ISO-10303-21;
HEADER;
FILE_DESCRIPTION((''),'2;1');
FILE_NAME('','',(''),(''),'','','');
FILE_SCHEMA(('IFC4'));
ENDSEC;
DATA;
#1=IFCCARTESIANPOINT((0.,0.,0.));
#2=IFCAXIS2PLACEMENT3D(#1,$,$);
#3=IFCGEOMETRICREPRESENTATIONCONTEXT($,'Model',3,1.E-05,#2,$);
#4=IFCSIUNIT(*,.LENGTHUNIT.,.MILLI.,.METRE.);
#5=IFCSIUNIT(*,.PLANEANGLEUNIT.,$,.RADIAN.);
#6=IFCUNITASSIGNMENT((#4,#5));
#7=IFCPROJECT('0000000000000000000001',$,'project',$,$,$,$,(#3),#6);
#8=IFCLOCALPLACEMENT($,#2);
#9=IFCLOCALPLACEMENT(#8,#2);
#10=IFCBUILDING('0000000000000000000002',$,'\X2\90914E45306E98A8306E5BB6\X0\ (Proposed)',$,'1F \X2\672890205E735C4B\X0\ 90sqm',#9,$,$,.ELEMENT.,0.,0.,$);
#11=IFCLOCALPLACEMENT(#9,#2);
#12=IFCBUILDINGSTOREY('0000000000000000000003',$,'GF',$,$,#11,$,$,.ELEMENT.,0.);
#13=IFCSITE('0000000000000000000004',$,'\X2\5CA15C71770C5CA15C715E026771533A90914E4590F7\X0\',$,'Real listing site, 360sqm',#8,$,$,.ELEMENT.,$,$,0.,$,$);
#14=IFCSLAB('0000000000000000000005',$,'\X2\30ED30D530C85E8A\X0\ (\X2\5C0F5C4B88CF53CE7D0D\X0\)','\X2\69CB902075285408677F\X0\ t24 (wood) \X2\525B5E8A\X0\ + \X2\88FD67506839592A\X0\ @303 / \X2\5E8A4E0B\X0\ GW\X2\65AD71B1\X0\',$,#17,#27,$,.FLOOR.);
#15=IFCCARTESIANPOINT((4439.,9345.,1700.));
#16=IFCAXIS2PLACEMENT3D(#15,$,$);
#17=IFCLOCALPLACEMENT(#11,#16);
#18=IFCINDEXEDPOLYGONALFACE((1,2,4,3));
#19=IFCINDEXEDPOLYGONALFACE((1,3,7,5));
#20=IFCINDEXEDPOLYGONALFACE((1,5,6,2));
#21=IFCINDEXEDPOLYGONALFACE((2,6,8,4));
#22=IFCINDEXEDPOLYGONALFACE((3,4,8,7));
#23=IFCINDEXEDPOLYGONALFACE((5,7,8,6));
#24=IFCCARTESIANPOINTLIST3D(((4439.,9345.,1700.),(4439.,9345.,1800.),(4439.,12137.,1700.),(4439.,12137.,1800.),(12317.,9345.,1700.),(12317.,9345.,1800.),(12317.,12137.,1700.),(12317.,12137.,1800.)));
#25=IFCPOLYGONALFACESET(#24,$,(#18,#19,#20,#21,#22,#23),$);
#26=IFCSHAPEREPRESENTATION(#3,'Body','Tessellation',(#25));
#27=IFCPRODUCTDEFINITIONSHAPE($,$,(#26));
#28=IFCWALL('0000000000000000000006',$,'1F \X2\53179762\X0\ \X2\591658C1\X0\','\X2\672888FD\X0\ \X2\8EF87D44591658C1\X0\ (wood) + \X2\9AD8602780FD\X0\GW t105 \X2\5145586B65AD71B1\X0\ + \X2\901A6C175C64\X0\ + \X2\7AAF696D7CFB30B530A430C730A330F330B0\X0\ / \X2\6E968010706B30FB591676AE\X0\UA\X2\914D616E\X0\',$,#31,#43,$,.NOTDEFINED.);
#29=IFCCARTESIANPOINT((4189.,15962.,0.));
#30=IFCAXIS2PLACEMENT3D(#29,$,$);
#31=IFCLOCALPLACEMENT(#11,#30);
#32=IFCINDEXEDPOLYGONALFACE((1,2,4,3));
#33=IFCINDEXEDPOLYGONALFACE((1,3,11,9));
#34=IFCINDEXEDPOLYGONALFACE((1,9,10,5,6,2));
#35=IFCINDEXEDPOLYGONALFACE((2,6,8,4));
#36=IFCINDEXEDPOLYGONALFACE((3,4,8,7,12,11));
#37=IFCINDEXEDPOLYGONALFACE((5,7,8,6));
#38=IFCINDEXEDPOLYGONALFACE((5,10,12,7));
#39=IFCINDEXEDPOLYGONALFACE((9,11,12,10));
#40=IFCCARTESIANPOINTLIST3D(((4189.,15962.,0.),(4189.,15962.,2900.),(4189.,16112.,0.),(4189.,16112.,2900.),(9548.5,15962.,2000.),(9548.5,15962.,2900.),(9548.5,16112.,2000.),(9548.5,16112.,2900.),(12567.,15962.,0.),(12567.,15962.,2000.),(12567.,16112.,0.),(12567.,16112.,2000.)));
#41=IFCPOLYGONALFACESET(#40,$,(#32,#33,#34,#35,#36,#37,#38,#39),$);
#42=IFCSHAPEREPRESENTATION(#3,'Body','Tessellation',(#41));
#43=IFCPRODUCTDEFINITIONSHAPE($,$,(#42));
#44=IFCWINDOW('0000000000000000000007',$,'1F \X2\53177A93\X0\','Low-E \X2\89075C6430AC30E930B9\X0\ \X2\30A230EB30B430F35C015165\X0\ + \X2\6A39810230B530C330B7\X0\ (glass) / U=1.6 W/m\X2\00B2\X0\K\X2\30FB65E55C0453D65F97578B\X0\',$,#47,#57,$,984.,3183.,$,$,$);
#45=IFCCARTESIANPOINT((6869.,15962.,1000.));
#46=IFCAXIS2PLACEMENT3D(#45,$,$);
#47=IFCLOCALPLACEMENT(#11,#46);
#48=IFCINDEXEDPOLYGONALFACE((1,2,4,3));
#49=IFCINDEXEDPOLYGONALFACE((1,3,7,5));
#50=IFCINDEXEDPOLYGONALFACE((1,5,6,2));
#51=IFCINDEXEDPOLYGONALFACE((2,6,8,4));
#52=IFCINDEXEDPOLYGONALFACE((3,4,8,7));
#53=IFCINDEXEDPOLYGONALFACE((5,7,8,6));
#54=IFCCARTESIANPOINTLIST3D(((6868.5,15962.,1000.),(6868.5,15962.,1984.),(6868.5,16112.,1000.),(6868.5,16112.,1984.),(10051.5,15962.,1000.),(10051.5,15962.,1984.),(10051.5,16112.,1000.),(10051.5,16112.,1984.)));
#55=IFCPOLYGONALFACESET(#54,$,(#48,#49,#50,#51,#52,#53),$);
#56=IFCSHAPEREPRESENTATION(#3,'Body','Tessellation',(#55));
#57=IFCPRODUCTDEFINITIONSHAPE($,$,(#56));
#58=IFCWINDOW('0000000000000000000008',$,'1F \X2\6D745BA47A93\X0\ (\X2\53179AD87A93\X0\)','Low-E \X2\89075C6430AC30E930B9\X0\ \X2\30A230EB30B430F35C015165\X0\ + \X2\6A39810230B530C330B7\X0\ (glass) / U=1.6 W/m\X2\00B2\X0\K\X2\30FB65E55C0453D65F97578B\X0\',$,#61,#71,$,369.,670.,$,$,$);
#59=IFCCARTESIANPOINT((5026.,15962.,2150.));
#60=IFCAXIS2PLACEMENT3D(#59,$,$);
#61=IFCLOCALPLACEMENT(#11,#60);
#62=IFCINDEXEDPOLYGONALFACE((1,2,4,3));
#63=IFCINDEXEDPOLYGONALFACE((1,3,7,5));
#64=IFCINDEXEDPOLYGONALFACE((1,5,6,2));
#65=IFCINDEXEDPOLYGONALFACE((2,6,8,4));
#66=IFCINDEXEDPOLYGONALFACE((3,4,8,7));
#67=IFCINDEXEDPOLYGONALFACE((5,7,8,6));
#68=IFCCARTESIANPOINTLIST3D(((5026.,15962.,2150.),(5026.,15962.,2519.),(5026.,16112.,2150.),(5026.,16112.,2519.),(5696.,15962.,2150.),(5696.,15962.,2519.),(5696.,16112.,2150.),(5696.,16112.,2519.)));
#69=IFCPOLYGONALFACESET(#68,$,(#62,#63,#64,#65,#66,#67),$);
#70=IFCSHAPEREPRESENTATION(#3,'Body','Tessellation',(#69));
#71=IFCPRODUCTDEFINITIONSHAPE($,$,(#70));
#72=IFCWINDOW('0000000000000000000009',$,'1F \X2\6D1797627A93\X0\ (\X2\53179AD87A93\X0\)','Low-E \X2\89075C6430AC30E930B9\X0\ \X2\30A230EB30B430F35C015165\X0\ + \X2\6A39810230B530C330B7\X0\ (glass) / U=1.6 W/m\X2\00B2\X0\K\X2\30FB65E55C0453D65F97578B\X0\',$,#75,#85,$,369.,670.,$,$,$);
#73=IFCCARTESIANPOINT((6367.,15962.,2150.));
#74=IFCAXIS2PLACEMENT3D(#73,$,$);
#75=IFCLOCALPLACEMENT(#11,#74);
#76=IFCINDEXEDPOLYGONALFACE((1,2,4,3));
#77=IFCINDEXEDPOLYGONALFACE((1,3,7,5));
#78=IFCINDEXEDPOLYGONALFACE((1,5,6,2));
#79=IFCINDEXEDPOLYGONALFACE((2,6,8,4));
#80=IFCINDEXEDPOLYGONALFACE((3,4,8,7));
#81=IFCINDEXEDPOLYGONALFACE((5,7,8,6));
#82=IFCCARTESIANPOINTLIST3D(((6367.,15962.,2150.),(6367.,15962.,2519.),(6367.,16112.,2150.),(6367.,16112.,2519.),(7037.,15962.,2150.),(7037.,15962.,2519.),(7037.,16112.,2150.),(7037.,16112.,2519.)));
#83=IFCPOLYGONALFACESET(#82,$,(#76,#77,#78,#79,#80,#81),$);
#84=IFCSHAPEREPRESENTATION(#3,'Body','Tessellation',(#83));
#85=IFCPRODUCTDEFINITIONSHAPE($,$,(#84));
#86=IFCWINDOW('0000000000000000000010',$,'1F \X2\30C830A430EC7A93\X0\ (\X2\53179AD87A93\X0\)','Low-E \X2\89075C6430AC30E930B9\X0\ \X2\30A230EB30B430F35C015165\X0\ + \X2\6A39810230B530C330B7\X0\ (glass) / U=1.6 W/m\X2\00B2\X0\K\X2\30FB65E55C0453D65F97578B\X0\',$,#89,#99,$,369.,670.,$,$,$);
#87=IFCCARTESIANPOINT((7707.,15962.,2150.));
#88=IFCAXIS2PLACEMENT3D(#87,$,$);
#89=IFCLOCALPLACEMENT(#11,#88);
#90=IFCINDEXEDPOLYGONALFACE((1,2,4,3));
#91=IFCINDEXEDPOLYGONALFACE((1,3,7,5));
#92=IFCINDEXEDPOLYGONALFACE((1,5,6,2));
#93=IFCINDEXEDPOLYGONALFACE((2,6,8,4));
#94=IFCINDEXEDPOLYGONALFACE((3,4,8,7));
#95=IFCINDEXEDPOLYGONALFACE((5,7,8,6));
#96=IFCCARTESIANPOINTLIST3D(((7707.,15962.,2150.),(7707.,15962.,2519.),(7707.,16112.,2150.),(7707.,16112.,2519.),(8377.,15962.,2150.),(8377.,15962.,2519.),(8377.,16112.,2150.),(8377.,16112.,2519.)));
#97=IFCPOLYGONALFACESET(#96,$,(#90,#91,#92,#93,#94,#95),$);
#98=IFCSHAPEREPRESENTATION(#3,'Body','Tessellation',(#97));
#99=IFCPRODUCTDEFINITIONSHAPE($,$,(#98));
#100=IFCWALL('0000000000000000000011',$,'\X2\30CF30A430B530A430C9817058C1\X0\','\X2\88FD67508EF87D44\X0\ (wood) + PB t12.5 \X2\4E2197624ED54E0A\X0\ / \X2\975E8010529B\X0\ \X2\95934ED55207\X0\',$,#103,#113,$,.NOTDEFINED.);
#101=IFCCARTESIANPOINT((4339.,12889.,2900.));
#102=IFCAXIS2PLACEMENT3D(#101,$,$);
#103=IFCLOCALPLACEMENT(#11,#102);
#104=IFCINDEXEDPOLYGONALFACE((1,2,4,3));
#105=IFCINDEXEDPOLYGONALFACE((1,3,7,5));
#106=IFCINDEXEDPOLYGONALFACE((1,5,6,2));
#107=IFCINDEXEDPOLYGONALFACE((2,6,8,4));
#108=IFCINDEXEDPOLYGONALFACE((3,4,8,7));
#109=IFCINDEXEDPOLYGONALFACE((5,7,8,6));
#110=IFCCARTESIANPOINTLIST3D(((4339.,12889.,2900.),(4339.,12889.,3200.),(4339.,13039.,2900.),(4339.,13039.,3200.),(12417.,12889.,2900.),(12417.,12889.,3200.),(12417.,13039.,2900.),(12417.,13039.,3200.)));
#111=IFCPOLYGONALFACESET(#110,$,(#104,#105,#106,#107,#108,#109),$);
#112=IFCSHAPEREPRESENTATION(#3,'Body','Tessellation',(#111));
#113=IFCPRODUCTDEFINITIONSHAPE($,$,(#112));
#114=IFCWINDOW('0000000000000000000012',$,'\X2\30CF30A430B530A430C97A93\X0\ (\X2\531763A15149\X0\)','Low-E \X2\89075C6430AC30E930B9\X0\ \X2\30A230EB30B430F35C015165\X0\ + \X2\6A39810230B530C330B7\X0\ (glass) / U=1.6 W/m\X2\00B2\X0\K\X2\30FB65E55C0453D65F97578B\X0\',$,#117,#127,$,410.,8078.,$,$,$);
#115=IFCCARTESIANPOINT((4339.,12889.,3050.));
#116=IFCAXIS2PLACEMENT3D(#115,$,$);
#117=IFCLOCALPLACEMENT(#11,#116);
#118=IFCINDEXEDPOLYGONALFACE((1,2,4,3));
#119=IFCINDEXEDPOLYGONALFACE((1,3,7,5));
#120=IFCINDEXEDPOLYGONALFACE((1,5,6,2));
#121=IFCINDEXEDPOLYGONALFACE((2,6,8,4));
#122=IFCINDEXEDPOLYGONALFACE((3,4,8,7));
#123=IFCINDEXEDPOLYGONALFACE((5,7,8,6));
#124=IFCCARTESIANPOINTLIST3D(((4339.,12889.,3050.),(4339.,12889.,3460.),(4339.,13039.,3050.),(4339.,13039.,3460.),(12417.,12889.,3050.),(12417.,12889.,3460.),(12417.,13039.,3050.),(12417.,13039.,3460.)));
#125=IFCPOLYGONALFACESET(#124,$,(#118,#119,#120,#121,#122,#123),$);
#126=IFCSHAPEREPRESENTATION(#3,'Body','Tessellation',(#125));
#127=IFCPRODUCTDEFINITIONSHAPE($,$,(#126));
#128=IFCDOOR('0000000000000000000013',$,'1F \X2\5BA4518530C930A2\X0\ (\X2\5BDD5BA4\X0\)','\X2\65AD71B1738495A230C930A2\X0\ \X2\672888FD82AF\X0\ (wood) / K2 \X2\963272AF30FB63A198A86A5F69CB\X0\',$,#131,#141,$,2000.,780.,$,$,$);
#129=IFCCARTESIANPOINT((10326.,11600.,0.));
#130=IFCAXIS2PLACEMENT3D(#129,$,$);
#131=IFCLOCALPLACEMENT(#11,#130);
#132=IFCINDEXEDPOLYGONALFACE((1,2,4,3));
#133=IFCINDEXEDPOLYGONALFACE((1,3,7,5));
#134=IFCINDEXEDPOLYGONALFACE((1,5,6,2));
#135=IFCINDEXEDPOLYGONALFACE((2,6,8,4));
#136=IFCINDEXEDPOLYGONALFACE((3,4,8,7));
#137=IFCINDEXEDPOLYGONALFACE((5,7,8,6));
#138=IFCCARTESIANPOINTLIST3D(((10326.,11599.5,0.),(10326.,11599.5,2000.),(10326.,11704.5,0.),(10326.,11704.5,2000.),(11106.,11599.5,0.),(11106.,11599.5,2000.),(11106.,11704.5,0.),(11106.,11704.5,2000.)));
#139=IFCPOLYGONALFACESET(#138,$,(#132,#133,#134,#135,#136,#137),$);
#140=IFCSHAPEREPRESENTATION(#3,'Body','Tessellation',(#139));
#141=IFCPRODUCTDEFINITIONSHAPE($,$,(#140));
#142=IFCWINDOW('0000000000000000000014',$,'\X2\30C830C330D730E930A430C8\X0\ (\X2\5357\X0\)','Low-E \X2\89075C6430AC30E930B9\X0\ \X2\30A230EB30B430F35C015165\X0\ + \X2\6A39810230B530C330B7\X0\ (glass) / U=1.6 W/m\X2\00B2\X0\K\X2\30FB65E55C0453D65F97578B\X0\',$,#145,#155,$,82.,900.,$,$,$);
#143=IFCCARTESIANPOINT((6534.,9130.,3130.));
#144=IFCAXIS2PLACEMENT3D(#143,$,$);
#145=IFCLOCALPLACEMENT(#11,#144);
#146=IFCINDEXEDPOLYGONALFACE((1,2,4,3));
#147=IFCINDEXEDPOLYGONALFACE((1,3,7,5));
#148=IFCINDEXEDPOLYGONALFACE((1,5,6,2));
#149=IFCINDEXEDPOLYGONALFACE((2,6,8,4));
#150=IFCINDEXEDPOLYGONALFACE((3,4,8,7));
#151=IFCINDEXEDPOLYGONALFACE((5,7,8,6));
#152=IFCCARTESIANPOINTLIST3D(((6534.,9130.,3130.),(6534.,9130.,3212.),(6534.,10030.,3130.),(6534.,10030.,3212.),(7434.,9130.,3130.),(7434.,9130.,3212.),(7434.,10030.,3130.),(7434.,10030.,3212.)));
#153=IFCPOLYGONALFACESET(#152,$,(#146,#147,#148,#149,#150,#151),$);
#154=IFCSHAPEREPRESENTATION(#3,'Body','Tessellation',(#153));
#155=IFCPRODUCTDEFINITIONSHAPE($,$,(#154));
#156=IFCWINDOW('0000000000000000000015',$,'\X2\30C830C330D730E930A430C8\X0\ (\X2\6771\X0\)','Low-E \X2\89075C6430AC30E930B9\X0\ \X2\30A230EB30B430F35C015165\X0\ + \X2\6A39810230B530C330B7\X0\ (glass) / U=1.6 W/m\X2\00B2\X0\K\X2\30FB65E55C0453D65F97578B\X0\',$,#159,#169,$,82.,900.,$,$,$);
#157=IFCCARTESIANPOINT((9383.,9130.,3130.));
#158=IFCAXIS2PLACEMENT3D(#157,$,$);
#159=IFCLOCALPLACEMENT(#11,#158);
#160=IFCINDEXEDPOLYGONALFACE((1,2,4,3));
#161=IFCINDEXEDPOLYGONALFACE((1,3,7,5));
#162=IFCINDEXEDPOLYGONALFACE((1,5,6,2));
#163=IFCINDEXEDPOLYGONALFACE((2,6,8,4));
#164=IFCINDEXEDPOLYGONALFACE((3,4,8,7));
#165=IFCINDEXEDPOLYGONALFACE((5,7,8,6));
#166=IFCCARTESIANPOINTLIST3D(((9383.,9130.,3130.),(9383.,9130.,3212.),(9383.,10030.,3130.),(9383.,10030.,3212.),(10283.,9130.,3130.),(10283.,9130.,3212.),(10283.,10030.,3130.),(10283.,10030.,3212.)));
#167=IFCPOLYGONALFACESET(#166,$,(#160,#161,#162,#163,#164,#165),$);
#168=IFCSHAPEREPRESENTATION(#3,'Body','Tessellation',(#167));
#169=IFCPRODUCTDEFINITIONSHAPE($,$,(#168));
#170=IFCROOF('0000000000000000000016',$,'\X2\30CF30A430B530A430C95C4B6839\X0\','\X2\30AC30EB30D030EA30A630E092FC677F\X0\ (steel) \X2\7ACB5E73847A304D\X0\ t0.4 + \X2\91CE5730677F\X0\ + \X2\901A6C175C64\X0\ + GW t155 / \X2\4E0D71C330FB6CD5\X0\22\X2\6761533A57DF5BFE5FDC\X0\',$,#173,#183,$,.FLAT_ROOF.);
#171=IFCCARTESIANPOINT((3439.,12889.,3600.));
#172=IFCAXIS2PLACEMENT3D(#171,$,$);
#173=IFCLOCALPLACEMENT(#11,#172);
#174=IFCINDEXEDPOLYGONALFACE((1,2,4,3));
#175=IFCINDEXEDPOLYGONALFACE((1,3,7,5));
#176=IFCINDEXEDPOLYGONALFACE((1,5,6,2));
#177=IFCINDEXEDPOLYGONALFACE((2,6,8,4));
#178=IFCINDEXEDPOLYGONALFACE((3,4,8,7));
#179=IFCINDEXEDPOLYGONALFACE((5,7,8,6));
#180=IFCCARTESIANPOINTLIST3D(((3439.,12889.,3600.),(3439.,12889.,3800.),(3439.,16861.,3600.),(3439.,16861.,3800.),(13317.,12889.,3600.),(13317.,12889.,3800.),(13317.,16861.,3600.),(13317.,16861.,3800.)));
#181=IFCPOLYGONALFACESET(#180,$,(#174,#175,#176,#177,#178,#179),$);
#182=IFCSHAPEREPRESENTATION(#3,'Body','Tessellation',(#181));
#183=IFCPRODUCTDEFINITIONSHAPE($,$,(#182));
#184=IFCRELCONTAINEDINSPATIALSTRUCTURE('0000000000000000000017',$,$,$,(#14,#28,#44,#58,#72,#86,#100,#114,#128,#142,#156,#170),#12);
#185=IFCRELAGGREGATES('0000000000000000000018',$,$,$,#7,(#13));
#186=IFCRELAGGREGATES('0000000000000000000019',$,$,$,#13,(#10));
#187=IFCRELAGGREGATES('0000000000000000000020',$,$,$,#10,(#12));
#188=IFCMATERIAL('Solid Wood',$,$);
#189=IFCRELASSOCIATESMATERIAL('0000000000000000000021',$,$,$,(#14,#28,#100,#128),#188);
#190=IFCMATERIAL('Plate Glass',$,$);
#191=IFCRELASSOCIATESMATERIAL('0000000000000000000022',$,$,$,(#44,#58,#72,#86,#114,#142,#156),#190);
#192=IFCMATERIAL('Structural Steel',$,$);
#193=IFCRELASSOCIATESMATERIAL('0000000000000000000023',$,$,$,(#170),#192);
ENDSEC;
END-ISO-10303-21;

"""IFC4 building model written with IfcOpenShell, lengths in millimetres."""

from ifc_helpers import new_model, si_unit, frame, frame_2d, origin, place, context, project, spatial, rectangle, extrude, material, element, fill, save


model = new_model("IFC4")

# Units and contexts
model_context = context("Model", 3, precision=1e-05, world=origin())
ifc_project = project(units=[si_unit("LENGTHUNIT", "METRE", prefix="MILLI"), si_unit("PLANEANGLEUNIT", "RADIAN")], contexts=[model_context])

# Site, building, storey
site_placement = place(None, origin())
site = spatial("IfcSite", under=ifc_project, at=site_placement, Name="岡山県岡山市東区邑久郷", ObjectType="Real listing site, 360sqm", CompositionType="ELEMENT", RefElevation=0.0)
building_placement = place(site_placement, origin())
building = spatial("IfcBuilding", under=site, at=building_placement, Name="邑久の風の家 (Proposed)", ObjectType="1F 木造平屋 90sqm", CompositionType="ELEMENT", ElevationOfRefHeight=0.0, ElevationOfTerrain=0.0)
storey_placement = place(building_placement, origin())
storey = spatial("IfcBuildingStorey", under=building, at=storey_placement, Name="GF", CompositionType="ELEMENT", Elevation=0.0)

# Slab
ifc_material_1 = material(Name="Solid Wood")
slab_placement = place(storey_placement, frame((4439.0, 9345.0, 1700.0)))
element("IfcSlab", 1, at=slab_placement, inside=storey, material=ifc_material_1, Name="ロフト床 (小屋裏収納)", Description="構造用合板 t24 (wood) 剛床 + 製材根太 @303 / 床下 GW断熱", PredefinedType="FLOOR", context=model_context, shape_type="SweptSolid", body=[
    extrude(rectangle(XDim=7878.0, YDim=2792.0, at=frame_2d((3939.0, 1396.0))), frame((4439.0, 9345.0, 1700.0)), (0.0, 0.0, 1.0), 100.0),
])

# Wall, openings, windows
wall_1_placement = place(storey_placement, frame((4189.0, 15962.0, 0.0)))
wall_1 = element("IfcWall", 2, at=wall_1_placement, inside=storey, material=ifc_material_1, Name="1F 北面 外壁", Description="木製 軸組外壁 (wood) + 高性能GW t105 充填断熱 + 通気層 + 窯業系サイディング / 準耐火・外皮UA配慮", PredefinedType="NOTDEFINED", context=model_context, shape_type="SweptSolid", body=[
    extrude(rectangle(XDim=8378.0, YDim=150.0, at=frame_2d((4189.0, 75.0))), frame((4189.0, 15962.0, 0.0)), (0.0, 0.0, 1.0), 2900.0),
])
opening_1_placement = place(storey_placement, frame((6869.0, 15962.0, 1000.0)))
opening_1 = element("IfcOpeningElement", 3, at=opening_1_placement, cuts=wall_1, PredefinedType="NOTDEFINED", context=model_context, shape_type="SweptSolid", body=[
    extrude(rectangle(XDim=3183.0, YDim=150.0, at=frame_2d((1591.0, 75.0))), frame((6869.0, 15962.0, 1000.0)), (0.0, 0.0, 1.0), 984.0),
])
opening_2_placement = place(storey_placement, frame((5026.0, 15962.0, 2150.0)))
opening_2 = element("IfcOpeningElement", 4, at=opening_2_placement, cuts=wall_1, PredefinedType="NOTDEFINED", context=model_context, shape_type="SweptSolid", body=[
    extrude(rectangle(XDim=670.0, YDim=150.0, at=frame_2d((335.0, 75.0))), frame((5026.0, 15962.0, 2150.0)), (0.0, 0.0, 1.0), 369.0),
])
opening_3_placement = place(storey_placement, frame((6367.0, 15962.0, 2150.0)))
opening_3 = element("IfcOpeningElement", 5, at=opening_3_placement, cuts=wall_1, PredefinedType="NOTDEFINED", context=model_context, shape_type="SweptSolid", body=[
    extrude(rectangle(XDim=670.0, YDim=150.0, at=frame_2d((335.0, 75.0))), frame((6367.0, 15962.0, 2150.0)), (0.0, 0.0, 1.0), 369.0),
])
opening_4_placement = place(storey_placement, frame((7707.0, 15962.0, 2150.0)))
opening_4 = element("IfcOpeningElement", 6, at=opening_4_placement, cuts=wall_1, PredefinedType="NOTDEFINED", context=model_context, shape_type="SweptSolid", body=[
    extrude(rectangle(XDim=670.0, YDim=150.0, at=frame_2d((335.0, 75.0))), frame((7707.0, 15962.0, 2150.0)), (0.0, 0.0, 1.0), 369.0),
])
ifc_material_2 = material(Name="Plate Glass")
window_1_placement = place(storey_placement, frame((6869.0, 15962.0, 1000.0)))
window_1 = element("IfcWindow", 7, at=window_1_placement, inside=storey, material=ifc_material_2, Name="1F 北窓", Description="Low-E 複層ガラス アルゴン封入 + 樹脂サッシ (glass) / U=1.6 W/m²K・日射取得型", OverallHeight=984.0, OverallWidth=3183.0, context=model_context, shape_type="SweptSolid", body=[
    extrude(rectangle(XDim=3183.0, YDim=150.0, at=frame_2d((1591.0, 75.0))), frame((6869.0, 15962.0, 1000.0)), (0.0, 0.0, 1.0), 984.0),
])
fill(opening_1, window_1)
window_2_placement = place(storey_placement, frame((5026.0, 15962.0, 2150.0)))
window_2 = element("IfcWindow", 8, at=window_2_placement, inside=storey, material=ifc_material_2, Name="1F 浴室窓 (北高窓)", Description="Low-E 複層ガラス アルゴン封入 + 樹脂サッシ (glass) / U=1.6 W/m²K・日射取得型", OverallHeight=369.0, OverallWidth=670.0, context=model_context, shape_type="SweptSolid", body=[
    extrude(rectangle(XDim=670.0, YDim=150.0, at=frame_2d((335.0, 75.0))), frame((5026.0, 15962.0, 2150.0)), (0.0, 0.0, 1.0), 369.0),
])
fill(opening_2, window_2)
window_3_placement = place(storey_placement, frame((6367.0, 15962.0, 2150.0)))
window_3 = element("IfcWindow", 9, at=window_3_placement, inside=storey, material=ifc_material_2, Name="1F 洗面窓 (北高窓)", Description="Low-E 複層ガラス アルゴン封入 + 樹脂サッシ (glass) / U=1.6 W/m²K・日射取得型", OverallHeight=369.0, OverallWidth=670.0, context=model_context, shape_type="SweptSolid", body=[
    extrude(rectangle(XDim=670.0, YDim=150.0, at=frame_2d((335.0, 75.0))), frame((6367.0, 15962.0, 2150.0)), (0.0, 0.0, 1.0), 369.0),
])
fill(opening_3, window_3)
window_4_placement = place(storey_placement, frame((7707.0, 15962.0, 2150.0)))
window_4 = element("IfcWindow", 10, at=window_4_placement, inside=storey, material=ifc_material_2, Name="1F トイレ窓 (北高窓)", Description="Low-E 複層ガラス アルゴン封入 + 樹脂サッシ (glass) / U=1.6 W/m²K・日射取得型", OverallHeight=369.0, OverallWidth=670.0, context=model_context, shape_type="SweptSolid", body=[
    extrude(rectangle(XDim=670.0, YDim=150.0, at=frame_2d((335.0, 75.0))), frame((7707.0, 15962.0, 2150.0)), (0.0, 0.0, 1.0), 369.0),
])
fill(opening_4, window_4)

# Wall, opening, window
wall_2_placement = place(storey_placement, frame((4339.0, 12889.0, 2900.0)))
wall_2 = element("IfcWall", 11, at=wall_2_placement, inside=storey, material=ifc_material_1, Name="ハイサイド腰壁", Description="製材軸組 (wood) + PB t12.5 両面仕上 / 非耐力 間仕切", PredefinedType="NOTDEFINED", context=model_context, shape_type="SweptSolid", body=[
    extrude(rectangle(XDim=8078.0, YDim=150.0, at=frame_2d((4039.0, 75.0))), frame((4339.0, 12889.0, 2900.0)), (0.0, 0.0, 1.0), 700.0),
])
opening_5_placement = place(storey_placement, frame((4339.0, 12889.0, 3050.0)))
opening_5 = element("IfcOpeningElement", 12, at=opening_5_placement, cuts=wall_2, PredefinedType="NOTDEFINED", context=model_context, shape_type="SweptSolid", body=[
    extrude(rectangle(XDim=8078.0, YDim=150.0, at=frame_2d((4039.0, 75.0))), frame((4339.0, 12889.0, 3050.0)), (0.0, 0.0, 1.0), 410.0),
])
window_5_placement = place(storey_placement, frame((4339.0, 12889.0, 3050.0)))
window_5 = element("IfcWindow", 13, at=window_5_placement, inside=storey, material=ifc_material_2, Name="ハイサイド窓 (北採光)", Description="Low-E 複層ガラス アルゴン封入 + 樹脂サッシ (glass) / U=1.6 W/m²K・日射取得型", OverallHeight=410.0, OverallWidth=8078.0, context=model_context, shape_type="SweptSolid", body=[
    extrude(rectangle(XDim=8078.0, YDim=150.0, at=frame_2d((4039.0, 75.0))), frame((4339.0, 12889.0, 3050.0)), (0.0, 0.0, 1.0), 410.0),
])
fill(opening_5, window_5)

# Door
door_1_placement = place(storey_placement, frame((10326.0, 11600.0, 0.0)))
element("IfcDoor", 14, at=door_1_placement, inside=storey, material=ifc_material_1, Name="1F 室内ドア (寝室)", Description="断熱玄関ドア 木製芯 (wood) / K2 防犯・採風機構", OverallHeight=2000.0, OverallWidth=780.0, context=model_context, shape_type="SweptSolid", body=[
    extrude(rectangle(XDim=780.0, YDim=105.0, at=frame_2d((390.0, 52.0))), frame((10326.0, 11600.0, 0.0)), (0.0, 0.0, 1.0), 2000.0),
])

# Windows
window_6_placement = place(storey_placement, frame((6534.0, 9130.0, 3130.0)))
element("IfcWindow", 15, at=window_6_placement, inside=storey, material=ifc_material_2, Name="トップライト (南)", Description="Low-E 複層ガラス アルゴン封入 + 樹脂サッシ (glass) / U=1.6 W/m²K・日射取得型", OverallHeight=82.0, OverallWidth=900.0, context=model_context, shape_type="SweptSolid", body=[
    extrude(rectangle(XDim=900.0, YDim=900.0, at=frame_2d((450.0, 450.0))), frame((6534.0, 9130.0, 3130.0)), (0.0, 0.0, 1.0), 82.0),
])
window_7_placement = place(storey_placement, frame((9383.0, 9130.0, 3130.0)))
element("IfcWindow", 16, at=window_7_placement, inside=storey, material=ifc_material_2, Name="トップライト (東)", Description="Low-E 複層ガラス アルゴン封入 + 樹脂サッシ (glass) / U=1.6 W/m²K・日射取得型", OverallHeight=82.0, OverallWidth=900.0, context=model_context, shape_type="SweptSolid", body=[
    extrude(rectangle(XDim=900.0, YDim=900.0, at=frame_2d((450.0, 450.0))), frame((9383.0, 9130.0, 3130.0)), (0.0, 0.0, 1.0), 82.0),
])

# Roof
ifc_material_3 = material(Name="Structural Steel")
roof_placement = place(storey_placement, frame((3439.0, 12889.0, 3600.0)))
element("IfcRoof", 17, at=roof_placement, inside=storey, material=ifc_material_3, Name="ハイサイド屋根", Description="ガルバリウム鋼板 (steel) 立平葺き t0.4 + 野地板 + 通気層 + GW t155 / 不燃・法22条区域対応", PredefinedType="FLAT_ROOF", context=model_context, shape_type="SweptSolid", body=[
    extrude(rectangle(XDim=9878.0, YDim=3972.0, at=frame_2d((4939.0, 1986.0))), frame((3439.0, 12889.0, 3600.0)), (0.0, 0.0, 1.0), 200.0),
])

save(model, "model.ifc")
